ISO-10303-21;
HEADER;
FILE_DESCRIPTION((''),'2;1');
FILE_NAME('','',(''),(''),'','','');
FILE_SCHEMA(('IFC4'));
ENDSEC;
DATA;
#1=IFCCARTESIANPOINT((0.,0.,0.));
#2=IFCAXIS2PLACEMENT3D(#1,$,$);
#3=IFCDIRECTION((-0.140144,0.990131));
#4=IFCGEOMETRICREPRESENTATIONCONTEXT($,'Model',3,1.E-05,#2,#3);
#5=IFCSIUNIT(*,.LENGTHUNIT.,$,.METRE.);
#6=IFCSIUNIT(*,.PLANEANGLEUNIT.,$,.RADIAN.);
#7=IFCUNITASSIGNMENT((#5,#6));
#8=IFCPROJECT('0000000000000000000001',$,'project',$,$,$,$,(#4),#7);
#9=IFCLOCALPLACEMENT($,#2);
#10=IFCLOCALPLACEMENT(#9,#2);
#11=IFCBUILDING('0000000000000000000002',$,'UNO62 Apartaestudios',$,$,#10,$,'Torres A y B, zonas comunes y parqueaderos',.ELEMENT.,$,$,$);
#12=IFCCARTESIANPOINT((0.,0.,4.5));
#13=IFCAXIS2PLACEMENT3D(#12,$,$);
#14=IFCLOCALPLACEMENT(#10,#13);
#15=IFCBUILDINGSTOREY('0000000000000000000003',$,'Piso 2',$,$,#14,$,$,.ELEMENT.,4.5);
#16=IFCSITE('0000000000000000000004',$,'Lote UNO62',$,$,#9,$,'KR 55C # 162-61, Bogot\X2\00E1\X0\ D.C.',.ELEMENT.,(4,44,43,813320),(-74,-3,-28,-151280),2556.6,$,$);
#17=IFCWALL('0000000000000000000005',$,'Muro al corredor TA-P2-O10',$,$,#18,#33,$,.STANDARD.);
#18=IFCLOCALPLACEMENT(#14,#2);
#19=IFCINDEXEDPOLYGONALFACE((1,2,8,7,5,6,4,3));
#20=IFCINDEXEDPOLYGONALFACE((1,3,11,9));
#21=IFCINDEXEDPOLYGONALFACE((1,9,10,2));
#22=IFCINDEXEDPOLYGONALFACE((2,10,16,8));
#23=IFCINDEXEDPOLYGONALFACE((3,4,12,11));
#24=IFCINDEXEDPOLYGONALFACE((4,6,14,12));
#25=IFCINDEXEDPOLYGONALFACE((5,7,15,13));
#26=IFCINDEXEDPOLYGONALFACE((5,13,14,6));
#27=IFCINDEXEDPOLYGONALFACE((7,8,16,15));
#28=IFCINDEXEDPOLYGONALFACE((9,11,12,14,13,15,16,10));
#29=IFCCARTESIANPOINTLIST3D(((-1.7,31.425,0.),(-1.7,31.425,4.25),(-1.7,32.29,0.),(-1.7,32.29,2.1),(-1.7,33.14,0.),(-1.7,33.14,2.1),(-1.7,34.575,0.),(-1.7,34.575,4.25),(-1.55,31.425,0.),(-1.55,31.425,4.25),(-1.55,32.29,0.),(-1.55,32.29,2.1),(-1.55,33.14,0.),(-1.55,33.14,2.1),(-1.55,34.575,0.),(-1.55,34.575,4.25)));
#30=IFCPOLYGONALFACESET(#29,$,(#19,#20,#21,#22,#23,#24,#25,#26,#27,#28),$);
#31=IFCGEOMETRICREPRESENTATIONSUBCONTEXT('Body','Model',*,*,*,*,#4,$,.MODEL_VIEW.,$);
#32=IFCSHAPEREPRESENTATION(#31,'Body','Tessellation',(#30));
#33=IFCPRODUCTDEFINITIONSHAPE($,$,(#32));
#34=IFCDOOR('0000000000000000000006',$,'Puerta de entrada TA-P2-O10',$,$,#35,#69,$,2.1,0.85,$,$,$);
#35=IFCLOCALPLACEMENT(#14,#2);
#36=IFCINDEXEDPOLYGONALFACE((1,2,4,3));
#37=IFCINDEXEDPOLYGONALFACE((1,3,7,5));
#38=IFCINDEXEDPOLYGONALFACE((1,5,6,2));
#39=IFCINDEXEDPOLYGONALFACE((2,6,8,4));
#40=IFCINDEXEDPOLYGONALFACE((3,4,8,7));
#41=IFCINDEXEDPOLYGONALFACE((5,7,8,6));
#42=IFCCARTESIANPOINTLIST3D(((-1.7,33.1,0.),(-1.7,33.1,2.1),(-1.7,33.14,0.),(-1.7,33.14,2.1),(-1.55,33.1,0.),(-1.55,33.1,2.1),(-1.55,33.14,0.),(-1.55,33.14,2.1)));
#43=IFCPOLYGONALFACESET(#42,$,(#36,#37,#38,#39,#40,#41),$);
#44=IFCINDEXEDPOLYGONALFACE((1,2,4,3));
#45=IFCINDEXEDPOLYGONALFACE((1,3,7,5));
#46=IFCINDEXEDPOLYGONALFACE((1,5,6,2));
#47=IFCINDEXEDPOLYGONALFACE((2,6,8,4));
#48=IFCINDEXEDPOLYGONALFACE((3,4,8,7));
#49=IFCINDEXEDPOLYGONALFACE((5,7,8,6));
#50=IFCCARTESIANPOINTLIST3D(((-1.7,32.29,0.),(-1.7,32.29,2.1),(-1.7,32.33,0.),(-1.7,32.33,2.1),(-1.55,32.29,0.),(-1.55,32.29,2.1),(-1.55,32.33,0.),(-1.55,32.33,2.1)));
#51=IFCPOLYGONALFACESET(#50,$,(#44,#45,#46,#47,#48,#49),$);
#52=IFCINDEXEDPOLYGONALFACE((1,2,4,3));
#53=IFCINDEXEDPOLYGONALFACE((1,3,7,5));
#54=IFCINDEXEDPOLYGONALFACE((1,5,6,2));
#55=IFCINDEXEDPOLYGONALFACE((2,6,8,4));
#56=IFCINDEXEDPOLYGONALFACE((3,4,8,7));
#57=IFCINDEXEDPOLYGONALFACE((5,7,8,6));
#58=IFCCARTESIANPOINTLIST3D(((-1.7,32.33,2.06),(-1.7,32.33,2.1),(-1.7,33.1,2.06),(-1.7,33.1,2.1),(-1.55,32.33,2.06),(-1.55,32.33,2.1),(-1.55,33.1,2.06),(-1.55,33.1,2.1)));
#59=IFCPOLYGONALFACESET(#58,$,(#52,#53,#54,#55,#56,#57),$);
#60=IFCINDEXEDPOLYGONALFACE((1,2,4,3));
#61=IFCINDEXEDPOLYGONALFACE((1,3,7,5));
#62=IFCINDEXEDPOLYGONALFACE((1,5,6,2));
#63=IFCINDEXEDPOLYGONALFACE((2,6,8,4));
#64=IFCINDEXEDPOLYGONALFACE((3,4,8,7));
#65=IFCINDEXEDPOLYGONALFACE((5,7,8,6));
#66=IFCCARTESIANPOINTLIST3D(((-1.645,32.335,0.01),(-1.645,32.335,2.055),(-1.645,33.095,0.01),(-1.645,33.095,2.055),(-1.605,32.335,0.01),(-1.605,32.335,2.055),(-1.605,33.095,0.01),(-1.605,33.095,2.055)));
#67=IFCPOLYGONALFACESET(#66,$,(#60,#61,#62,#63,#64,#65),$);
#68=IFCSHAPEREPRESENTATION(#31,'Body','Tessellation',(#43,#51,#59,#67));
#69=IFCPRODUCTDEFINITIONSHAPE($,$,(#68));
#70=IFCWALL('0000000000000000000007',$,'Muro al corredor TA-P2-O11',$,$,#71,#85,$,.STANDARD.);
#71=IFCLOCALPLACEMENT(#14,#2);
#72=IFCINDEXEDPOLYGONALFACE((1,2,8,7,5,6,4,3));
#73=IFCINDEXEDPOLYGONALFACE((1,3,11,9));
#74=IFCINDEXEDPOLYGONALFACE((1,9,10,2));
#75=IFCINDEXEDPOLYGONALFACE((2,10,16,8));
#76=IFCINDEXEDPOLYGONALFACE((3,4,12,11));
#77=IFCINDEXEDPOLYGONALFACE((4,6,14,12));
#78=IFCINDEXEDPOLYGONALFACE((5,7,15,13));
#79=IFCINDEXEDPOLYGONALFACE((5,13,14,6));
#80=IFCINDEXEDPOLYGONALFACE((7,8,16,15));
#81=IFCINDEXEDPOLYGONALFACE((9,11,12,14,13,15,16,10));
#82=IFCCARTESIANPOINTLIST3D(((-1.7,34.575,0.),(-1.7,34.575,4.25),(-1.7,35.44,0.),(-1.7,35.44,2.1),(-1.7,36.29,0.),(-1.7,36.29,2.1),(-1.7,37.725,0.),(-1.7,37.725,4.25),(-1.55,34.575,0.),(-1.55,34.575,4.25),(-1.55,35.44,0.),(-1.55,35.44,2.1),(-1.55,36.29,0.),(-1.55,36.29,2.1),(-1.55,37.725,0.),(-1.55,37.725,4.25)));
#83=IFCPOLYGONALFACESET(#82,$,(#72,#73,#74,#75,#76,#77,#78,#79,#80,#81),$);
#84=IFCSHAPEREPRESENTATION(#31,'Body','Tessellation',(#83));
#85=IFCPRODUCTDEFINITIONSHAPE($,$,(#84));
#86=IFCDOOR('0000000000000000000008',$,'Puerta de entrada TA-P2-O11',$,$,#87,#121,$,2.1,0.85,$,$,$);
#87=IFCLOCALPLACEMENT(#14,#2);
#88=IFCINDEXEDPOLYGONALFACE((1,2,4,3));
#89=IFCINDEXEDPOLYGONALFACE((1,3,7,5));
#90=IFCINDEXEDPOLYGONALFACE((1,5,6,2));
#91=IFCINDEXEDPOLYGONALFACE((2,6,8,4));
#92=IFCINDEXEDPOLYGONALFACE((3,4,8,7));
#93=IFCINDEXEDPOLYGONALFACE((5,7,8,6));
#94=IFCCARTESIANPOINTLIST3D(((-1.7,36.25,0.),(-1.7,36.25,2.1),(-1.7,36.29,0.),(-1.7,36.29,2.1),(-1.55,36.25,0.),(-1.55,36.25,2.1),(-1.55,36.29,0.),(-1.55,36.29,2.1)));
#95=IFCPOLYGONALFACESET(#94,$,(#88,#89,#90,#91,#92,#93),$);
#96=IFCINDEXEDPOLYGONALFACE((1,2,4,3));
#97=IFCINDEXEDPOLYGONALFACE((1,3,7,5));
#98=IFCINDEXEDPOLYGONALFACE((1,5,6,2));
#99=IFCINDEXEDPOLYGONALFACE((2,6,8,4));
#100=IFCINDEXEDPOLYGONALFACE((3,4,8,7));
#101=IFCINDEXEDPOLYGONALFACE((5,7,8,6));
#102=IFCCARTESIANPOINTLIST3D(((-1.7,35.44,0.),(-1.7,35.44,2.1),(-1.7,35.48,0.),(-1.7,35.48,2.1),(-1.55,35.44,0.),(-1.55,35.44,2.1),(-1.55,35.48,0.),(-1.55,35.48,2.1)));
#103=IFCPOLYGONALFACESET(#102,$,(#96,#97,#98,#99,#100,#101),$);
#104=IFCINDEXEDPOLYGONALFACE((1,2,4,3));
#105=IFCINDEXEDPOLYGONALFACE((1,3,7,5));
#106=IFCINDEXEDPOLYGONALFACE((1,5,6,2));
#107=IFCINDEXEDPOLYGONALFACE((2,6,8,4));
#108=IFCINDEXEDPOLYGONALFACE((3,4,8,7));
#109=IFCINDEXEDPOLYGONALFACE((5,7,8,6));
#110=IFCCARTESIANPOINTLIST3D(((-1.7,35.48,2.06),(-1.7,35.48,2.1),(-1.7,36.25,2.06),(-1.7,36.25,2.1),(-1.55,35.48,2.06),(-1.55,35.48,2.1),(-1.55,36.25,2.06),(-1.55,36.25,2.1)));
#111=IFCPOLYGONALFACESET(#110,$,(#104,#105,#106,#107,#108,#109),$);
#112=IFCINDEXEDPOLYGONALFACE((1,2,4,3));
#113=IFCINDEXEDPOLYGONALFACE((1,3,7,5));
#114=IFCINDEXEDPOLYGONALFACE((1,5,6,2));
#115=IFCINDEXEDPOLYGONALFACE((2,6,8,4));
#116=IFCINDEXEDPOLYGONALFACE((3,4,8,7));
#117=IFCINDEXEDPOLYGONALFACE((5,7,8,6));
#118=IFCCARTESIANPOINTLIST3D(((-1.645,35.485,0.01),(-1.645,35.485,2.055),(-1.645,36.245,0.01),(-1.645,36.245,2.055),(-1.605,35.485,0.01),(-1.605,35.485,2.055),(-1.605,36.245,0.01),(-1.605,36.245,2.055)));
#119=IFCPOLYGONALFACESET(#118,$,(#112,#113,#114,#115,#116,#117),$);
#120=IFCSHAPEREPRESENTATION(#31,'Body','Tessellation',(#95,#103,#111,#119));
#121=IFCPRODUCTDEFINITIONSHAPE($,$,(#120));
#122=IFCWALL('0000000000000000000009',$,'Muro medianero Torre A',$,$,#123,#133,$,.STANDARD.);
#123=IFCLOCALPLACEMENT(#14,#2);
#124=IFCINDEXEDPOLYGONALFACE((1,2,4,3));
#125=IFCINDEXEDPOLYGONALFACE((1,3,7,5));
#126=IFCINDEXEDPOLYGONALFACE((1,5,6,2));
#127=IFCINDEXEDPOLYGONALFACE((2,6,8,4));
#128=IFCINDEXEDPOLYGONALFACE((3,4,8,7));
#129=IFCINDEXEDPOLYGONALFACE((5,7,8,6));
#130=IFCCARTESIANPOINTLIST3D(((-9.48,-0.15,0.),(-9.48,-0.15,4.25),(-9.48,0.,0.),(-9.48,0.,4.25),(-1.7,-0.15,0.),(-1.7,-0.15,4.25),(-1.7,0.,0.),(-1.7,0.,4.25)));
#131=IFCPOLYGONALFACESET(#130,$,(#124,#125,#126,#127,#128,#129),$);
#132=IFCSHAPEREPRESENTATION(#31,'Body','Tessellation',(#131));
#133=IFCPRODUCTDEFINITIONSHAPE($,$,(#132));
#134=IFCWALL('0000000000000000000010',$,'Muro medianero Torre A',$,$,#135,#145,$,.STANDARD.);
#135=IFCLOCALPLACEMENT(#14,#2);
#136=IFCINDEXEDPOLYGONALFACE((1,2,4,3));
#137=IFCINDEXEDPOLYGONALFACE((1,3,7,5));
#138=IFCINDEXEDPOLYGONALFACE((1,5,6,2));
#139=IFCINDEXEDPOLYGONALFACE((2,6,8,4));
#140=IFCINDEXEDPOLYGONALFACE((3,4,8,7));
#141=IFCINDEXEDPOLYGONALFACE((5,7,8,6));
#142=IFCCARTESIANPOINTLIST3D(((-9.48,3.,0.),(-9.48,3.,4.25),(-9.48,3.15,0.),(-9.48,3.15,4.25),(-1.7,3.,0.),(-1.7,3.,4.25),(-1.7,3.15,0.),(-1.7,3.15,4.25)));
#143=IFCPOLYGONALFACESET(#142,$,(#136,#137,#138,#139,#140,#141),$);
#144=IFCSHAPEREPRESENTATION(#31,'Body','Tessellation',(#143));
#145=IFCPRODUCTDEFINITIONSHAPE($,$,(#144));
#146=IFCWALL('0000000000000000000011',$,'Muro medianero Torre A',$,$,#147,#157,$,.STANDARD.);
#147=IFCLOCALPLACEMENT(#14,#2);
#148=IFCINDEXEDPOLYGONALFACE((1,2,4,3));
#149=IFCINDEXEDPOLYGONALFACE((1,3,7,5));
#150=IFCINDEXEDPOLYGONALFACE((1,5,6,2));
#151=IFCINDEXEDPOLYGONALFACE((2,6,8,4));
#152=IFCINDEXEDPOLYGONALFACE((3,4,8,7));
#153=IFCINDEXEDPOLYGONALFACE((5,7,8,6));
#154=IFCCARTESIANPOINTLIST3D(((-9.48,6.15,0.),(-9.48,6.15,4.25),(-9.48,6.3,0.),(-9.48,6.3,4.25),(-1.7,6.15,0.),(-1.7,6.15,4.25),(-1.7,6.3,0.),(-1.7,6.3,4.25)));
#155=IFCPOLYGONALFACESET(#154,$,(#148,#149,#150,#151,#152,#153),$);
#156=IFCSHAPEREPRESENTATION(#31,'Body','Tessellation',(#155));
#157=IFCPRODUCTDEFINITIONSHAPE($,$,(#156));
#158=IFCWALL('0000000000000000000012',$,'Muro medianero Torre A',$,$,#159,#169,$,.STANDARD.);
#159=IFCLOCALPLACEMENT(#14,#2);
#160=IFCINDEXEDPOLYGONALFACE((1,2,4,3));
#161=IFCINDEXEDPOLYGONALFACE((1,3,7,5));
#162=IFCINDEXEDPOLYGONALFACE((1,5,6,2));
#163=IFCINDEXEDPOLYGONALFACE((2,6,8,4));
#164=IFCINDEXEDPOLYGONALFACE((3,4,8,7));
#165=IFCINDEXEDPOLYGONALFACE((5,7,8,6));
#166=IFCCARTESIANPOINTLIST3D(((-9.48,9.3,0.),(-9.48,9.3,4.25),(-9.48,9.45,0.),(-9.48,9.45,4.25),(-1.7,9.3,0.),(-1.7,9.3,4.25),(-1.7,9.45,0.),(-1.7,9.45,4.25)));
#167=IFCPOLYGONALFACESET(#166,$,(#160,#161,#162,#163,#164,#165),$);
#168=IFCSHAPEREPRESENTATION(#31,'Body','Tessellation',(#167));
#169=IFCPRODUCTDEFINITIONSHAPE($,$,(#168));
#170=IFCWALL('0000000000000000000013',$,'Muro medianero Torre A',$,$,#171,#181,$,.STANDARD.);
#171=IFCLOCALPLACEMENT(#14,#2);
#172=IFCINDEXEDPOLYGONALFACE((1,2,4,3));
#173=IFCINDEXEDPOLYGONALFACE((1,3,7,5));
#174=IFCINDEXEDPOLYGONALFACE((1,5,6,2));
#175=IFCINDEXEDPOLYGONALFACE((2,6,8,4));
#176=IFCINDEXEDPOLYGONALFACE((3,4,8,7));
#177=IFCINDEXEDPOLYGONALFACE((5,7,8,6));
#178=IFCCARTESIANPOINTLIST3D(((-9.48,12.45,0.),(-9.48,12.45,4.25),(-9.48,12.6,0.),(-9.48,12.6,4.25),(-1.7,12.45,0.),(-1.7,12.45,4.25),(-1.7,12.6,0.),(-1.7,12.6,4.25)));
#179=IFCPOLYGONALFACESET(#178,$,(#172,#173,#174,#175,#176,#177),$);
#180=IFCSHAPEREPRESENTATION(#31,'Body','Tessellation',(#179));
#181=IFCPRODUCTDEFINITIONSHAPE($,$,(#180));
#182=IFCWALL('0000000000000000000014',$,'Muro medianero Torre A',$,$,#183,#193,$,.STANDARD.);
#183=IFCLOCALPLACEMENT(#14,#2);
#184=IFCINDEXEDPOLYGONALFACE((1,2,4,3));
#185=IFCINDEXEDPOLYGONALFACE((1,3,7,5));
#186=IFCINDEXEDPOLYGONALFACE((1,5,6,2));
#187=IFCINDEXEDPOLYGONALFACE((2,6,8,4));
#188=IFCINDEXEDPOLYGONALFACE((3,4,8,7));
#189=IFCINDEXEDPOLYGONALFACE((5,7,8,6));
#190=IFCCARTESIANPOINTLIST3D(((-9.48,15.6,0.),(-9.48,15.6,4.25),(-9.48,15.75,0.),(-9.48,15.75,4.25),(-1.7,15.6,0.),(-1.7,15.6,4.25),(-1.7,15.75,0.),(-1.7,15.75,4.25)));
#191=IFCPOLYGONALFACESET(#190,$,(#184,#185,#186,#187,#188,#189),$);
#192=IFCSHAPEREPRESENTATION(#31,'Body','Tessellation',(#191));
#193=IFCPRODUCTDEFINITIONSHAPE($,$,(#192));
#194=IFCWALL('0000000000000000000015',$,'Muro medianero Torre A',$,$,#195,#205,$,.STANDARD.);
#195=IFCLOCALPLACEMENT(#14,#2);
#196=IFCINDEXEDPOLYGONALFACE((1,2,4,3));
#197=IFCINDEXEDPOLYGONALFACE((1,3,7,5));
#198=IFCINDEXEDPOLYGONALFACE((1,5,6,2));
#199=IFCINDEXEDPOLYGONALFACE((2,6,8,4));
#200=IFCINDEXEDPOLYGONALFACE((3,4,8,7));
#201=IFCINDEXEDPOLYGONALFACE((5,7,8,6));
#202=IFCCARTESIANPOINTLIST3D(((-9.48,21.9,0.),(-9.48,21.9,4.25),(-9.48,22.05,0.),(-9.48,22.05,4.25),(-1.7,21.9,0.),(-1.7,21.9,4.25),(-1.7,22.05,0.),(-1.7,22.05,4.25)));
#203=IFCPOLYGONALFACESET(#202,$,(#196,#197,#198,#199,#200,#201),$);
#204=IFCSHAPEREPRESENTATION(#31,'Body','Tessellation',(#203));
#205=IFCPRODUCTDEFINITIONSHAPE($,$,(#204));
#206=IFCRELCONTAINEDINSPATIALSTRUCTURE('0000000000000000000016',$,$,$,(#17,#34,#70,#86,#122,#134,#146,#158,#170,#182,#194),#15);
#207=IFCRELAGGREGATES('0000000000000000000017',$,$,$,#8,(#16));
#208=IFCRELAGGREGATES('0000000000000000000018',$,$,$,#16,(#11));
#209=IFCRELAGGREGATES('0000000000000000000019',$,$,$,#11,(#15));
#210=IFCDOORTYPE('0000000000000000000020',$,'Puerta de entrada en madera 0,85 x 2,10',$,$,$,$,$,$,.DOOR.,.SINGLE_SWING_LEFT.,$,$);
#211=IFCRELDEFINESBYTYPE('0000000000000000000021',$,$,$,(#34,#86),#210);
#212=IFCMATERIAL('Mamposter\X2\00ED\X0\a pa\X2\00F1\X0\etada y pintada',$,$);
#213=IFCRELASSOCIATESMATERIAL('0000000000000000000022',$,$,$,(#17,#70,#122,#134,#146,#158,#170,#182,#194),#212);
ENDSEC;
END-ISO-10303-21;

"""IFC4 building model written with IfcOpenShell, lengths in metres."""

from ifc_helpers import new_model, si_unit, direction, frame, frame_2d, origin, place, context, subcontext, project, spatial, rectangle, extrude, source, transform, mapped, material, type_object, type_shapes, element, fill, save


model = new_model("IFC4")

# Units and contexts
model_context = context("Model", 3, precision=1e-05, world=origin(), true_north=direction((-0.140144, 0.990131)))
body_context = subcontext(model_context, "Body", "Model", "MODEL_VIEW")
ifc_project = project(units=[si_unit("LENGTHUNIT", "METRE"), si_unit("PLANEANGLEUNIT", "RADIAN")], contexts=[model_context])

# Site, building, storey
site_placement = place(None, origin())
site = spatial("IfcSite", under=ifc_project, at=site_placement, Name="Lote UNO62", LongName="KR 55C # 162-61, Bogotá D.C.", CompositionType="ELEMENT", RefLatitude=(4, 44, 43, 813320), RefLongitude=(-74, -3, -28, -151280), RefElevation=2556.6)
building_placement = place(site_placement, origin())
building = spatial("IfcBuilding", under=site, at=building_placement, Name="UNO62 Apartaestudios", LongName="Torres A y B, zonas comunes y parqueaderos", CompositionType="ELEMENT")
storey_placement = place(building_placement, frame((0.0, 0.0, 4.5)))
storey = spatial("IfcBuildingStorey", under=building, at=storey_placement, Name="Piso 2", CompositionType="ELEMENT", Elevation=4.5)

# Walls, openings, doors
ifc_material = material(Name="Mampostería pañetada y pintada")
door_type = type_object("IfcDoorType", Name="Puerta de entrada en madera 0,85 x 2,10", OperationType="SINGLE_SWING_LEFT", PredefinedType="DOOR")
shared_shape = source(origin(), body_context, "Body", "SweptSolid", [
    extrude(rectangle(XDim=0.15, YDim=0.04, at=frame_2d((-0.075, 1.38))), origin(), (0.0, 0.0, 1.0), 2.1),
    extrude(rectangle(XDim=0.15, YDim=0.04, at=frame_2d((-0.075, 2.19))), origin(), (0.0, 0.0, 1.0), 2.1),
    extrude(rectangle(XDim=0.15, YDim=0.77, at=frame_2d((-0.075, 1.785))), frame((0.0, 0.0, 2.06)), (0.0, 0.0, 1.0), 0.04),
    extrude(rectangle(XDim=0.04, YDim=0.76, at=frame_2d((-0.075, 1.785))), frame((0.0, 0.0, 0.01)), (0.0, 0.0, 1.0), 2.045),
])
type_shapes(door_type, [shared_shape])
wall_1_placement = place(storey_placement, origin())
wall_1 = element("IfcWall", 1, at=wall_1_placement, inside=storey, material=ifc_material, Name="Muro al corredor TA-P2-O10", PredefinedType="STANDARD", context=body_context, shape_type="SweptSolid", body=[
    extrude(rectangle(XDim=0.15, YDim=3.15, at=frame_2d((-1.625, 33.0))), origin(), (0.0, 0.0, 1.0), 4.25),
])
opening_1_placement = place(wall_1_placement, origin())
opening_1 = element("IfcOpeningElement", 2, at=opening_1_placement, cuts=wall_1, PredefinedType="OPENING", context=body_context, shape_type="SweptSolid", body=[
    extrude(rectangle(XDim=0.25, YDim=0.85, at=frame_2d((-1.625, 32.715))), origin(), (0.0, 0.0, 1.0), 2.1),
])
placement_1 = place(storey_placement, frame((-1.7, 34.5, 0.0), z_axis=(0.0, 0.0, 1.0), x_axis=(-1.0, 0.0, 0.0)))
door_1_placement = place(placement_1, origin())
door_1 = element("IfcDoor", 3, at=door_1_placement, inside=storey, type_object=door_type, Name="Puerta de entrada TA-P2-O10", OverallHeight=2.1, OverallWidth=0.85, context=body_context, shape_type="MappedRepresentation", body=[
    mapped(shared_shape, transform((0.0, 0.0, 0.0))),
])
fill(opening_1, door_1)
wall_2_placement = place(storey_placement, origin())
wall_2 = element("IfcWall", 4, at=wall_2_placement, inside=storey, material=ifc_material, Name="Muro al corredor TA-P2-O11", PredefinedType="STANDARD", context=body_context, shape_type="SweptSolid", body=[
    extrude(rectangle(XDim=0.15, YDim=3.15, at=frame_2d((-1.625, 36.15))), origin(), (0.0, 0.0, 1.0), 4.25),
])
opening_2_placement = place(wall_2_placement, origin())
opening_2 = element("IfcOpeningElement", 5, at=opening_2_placement, cuts=wall_2, PredefinedType="OPENING", context=body_context, shape_type="SweptSolid", body=[
    extrude(rectangle(XDim=0.25, YDim=0.85, at=frame_2d((-1.625, 35.865))), origin(), (0.0, 0.0, 1.0), 2.1),
])
placement_2 = place(storey_placement, frame((-1.7, 37.65, 0.0), z_axis=(0.0, 0.0, 1.0), x_axis=(-1.0, 0.0, 0.0)))
door_2_placement = place(placement_2, origin())
door_2 = element("IfcDoor", 6, at=door_2_placement, inside=storey, type_object=door_type, Name="Puerta de entrada TA-P2-O11", OverallHeight=2.1, OverallWidth=0.85, context=body_context, shape_type="MappedRepresentation", body=[
    mapped(shared_shape, transform((0.0, 0.0, 0.0))),
])
fill(opening_2, door_2)

# Walls
wall_3_placement = place(storey_placement, origin())
element("IfcWall", 7, at=wall_3_placement, inside=storey, material=ifc_material, Name="Muro medianero Torre A", PredefinedType="STANDARD", context=body_context, shape_type="SweptSolid", body=[
    extrude(rectangle(XDim=7.78, YDim=0.15, at=frame_2d((-5.59, -0.075))), origin(), (0.0, 0.0, 1.0), 4.25),
])
wall_4_placement = place(storey_placement, origin())
element("IfcWall", 8, at=wall_4_placement, inside=storey, material=ifc_material, Name="Muro medianero Torre A", PredefinedType="STANDARD", context=body_context, shape_type="SweptSolid", body=[
    extrude(rectangle(XDim=7.78, YDim=0.15, at=frame_2d((-5.59, 3.075))), origin(), (0.0, 0.0, 1.0), 4.25),
])
wall_5_placement = place(storey_placement, origin())
element("IfcWall", 9, at=wall_5_placement, inside=storey, material=ifc_material, Name="Muro medianero Torre A", PredefinedType="STANDARD", context=body_context, shape_type="SweptSolid", body=[
    extrude(rectangle(XDim=7.78, YDim=0.15, at=frame_2d((-5.59, 6.225))), origin(), (0.0, 0.0, 1.0), 4.25),
])
wall_6_placement = place(storey_placement, origin())
element("IfcWall", 10, at=wall_6_placement, inside=storey, material=ifc_material, Name="Muro medianero Torre A", PredefinedType="STANDARD", context=body_context, shape_type="SweptSolid", body=[
    extrude(rectangle(XDim=7.78, YDim=0.15, at=frame_2d((-5.59, 9.375))), origin(), (0.0, 0.0, 1.0), 4.25),
])
wall_7_placement = place(storey_placement, origin())
element("IfcWall", 11, at=wall_7_placement, inside=storey, material=ifc_material, Name="Muro medianero Torre A", PredefinedType="STANDARD", context=body_context, shape_type="SweptSolid", body=[
    extrude(rectangle(XDim=7.78, YDim=0.15, at=frame_2d((-5.59, 12.525))), origin(), (0.0, 0.0, 1.0), 4.25),
])
wall_8_placement = place(storey_placement, origin())
element("IfcWall", 12, at=wall_8_placement, inside=storey, material=ifc_material, Name="Muro medianero Torre A", PredefinedType="STANDARD", context=body_context, shape_type="SweptSolid", body=[
    extrude(rectangle(XDim=7.78, YDim=0.15, at=frame_2d((-5.59, 15.675))), origin(), (0.0, 0.0, 1.0), 4.25),
])
wall_9_placement = place(storey_placement, origin())
element("IfcWall", 13, at=wall_9_placement, inside=storey, material=ifc_material, Name="Muro medianero Torre A", PredefinedType="STANDARD", context=body_context, shape_type="SweptSolid", body=[
    extrude(rectangle(XDim=7.78, YDim=0.15, at=frame_2d((-5.59, 21.975))), origin(), (0.0, 0.0, 1.0), 4.25),
])

save(model, "model.ifc")
